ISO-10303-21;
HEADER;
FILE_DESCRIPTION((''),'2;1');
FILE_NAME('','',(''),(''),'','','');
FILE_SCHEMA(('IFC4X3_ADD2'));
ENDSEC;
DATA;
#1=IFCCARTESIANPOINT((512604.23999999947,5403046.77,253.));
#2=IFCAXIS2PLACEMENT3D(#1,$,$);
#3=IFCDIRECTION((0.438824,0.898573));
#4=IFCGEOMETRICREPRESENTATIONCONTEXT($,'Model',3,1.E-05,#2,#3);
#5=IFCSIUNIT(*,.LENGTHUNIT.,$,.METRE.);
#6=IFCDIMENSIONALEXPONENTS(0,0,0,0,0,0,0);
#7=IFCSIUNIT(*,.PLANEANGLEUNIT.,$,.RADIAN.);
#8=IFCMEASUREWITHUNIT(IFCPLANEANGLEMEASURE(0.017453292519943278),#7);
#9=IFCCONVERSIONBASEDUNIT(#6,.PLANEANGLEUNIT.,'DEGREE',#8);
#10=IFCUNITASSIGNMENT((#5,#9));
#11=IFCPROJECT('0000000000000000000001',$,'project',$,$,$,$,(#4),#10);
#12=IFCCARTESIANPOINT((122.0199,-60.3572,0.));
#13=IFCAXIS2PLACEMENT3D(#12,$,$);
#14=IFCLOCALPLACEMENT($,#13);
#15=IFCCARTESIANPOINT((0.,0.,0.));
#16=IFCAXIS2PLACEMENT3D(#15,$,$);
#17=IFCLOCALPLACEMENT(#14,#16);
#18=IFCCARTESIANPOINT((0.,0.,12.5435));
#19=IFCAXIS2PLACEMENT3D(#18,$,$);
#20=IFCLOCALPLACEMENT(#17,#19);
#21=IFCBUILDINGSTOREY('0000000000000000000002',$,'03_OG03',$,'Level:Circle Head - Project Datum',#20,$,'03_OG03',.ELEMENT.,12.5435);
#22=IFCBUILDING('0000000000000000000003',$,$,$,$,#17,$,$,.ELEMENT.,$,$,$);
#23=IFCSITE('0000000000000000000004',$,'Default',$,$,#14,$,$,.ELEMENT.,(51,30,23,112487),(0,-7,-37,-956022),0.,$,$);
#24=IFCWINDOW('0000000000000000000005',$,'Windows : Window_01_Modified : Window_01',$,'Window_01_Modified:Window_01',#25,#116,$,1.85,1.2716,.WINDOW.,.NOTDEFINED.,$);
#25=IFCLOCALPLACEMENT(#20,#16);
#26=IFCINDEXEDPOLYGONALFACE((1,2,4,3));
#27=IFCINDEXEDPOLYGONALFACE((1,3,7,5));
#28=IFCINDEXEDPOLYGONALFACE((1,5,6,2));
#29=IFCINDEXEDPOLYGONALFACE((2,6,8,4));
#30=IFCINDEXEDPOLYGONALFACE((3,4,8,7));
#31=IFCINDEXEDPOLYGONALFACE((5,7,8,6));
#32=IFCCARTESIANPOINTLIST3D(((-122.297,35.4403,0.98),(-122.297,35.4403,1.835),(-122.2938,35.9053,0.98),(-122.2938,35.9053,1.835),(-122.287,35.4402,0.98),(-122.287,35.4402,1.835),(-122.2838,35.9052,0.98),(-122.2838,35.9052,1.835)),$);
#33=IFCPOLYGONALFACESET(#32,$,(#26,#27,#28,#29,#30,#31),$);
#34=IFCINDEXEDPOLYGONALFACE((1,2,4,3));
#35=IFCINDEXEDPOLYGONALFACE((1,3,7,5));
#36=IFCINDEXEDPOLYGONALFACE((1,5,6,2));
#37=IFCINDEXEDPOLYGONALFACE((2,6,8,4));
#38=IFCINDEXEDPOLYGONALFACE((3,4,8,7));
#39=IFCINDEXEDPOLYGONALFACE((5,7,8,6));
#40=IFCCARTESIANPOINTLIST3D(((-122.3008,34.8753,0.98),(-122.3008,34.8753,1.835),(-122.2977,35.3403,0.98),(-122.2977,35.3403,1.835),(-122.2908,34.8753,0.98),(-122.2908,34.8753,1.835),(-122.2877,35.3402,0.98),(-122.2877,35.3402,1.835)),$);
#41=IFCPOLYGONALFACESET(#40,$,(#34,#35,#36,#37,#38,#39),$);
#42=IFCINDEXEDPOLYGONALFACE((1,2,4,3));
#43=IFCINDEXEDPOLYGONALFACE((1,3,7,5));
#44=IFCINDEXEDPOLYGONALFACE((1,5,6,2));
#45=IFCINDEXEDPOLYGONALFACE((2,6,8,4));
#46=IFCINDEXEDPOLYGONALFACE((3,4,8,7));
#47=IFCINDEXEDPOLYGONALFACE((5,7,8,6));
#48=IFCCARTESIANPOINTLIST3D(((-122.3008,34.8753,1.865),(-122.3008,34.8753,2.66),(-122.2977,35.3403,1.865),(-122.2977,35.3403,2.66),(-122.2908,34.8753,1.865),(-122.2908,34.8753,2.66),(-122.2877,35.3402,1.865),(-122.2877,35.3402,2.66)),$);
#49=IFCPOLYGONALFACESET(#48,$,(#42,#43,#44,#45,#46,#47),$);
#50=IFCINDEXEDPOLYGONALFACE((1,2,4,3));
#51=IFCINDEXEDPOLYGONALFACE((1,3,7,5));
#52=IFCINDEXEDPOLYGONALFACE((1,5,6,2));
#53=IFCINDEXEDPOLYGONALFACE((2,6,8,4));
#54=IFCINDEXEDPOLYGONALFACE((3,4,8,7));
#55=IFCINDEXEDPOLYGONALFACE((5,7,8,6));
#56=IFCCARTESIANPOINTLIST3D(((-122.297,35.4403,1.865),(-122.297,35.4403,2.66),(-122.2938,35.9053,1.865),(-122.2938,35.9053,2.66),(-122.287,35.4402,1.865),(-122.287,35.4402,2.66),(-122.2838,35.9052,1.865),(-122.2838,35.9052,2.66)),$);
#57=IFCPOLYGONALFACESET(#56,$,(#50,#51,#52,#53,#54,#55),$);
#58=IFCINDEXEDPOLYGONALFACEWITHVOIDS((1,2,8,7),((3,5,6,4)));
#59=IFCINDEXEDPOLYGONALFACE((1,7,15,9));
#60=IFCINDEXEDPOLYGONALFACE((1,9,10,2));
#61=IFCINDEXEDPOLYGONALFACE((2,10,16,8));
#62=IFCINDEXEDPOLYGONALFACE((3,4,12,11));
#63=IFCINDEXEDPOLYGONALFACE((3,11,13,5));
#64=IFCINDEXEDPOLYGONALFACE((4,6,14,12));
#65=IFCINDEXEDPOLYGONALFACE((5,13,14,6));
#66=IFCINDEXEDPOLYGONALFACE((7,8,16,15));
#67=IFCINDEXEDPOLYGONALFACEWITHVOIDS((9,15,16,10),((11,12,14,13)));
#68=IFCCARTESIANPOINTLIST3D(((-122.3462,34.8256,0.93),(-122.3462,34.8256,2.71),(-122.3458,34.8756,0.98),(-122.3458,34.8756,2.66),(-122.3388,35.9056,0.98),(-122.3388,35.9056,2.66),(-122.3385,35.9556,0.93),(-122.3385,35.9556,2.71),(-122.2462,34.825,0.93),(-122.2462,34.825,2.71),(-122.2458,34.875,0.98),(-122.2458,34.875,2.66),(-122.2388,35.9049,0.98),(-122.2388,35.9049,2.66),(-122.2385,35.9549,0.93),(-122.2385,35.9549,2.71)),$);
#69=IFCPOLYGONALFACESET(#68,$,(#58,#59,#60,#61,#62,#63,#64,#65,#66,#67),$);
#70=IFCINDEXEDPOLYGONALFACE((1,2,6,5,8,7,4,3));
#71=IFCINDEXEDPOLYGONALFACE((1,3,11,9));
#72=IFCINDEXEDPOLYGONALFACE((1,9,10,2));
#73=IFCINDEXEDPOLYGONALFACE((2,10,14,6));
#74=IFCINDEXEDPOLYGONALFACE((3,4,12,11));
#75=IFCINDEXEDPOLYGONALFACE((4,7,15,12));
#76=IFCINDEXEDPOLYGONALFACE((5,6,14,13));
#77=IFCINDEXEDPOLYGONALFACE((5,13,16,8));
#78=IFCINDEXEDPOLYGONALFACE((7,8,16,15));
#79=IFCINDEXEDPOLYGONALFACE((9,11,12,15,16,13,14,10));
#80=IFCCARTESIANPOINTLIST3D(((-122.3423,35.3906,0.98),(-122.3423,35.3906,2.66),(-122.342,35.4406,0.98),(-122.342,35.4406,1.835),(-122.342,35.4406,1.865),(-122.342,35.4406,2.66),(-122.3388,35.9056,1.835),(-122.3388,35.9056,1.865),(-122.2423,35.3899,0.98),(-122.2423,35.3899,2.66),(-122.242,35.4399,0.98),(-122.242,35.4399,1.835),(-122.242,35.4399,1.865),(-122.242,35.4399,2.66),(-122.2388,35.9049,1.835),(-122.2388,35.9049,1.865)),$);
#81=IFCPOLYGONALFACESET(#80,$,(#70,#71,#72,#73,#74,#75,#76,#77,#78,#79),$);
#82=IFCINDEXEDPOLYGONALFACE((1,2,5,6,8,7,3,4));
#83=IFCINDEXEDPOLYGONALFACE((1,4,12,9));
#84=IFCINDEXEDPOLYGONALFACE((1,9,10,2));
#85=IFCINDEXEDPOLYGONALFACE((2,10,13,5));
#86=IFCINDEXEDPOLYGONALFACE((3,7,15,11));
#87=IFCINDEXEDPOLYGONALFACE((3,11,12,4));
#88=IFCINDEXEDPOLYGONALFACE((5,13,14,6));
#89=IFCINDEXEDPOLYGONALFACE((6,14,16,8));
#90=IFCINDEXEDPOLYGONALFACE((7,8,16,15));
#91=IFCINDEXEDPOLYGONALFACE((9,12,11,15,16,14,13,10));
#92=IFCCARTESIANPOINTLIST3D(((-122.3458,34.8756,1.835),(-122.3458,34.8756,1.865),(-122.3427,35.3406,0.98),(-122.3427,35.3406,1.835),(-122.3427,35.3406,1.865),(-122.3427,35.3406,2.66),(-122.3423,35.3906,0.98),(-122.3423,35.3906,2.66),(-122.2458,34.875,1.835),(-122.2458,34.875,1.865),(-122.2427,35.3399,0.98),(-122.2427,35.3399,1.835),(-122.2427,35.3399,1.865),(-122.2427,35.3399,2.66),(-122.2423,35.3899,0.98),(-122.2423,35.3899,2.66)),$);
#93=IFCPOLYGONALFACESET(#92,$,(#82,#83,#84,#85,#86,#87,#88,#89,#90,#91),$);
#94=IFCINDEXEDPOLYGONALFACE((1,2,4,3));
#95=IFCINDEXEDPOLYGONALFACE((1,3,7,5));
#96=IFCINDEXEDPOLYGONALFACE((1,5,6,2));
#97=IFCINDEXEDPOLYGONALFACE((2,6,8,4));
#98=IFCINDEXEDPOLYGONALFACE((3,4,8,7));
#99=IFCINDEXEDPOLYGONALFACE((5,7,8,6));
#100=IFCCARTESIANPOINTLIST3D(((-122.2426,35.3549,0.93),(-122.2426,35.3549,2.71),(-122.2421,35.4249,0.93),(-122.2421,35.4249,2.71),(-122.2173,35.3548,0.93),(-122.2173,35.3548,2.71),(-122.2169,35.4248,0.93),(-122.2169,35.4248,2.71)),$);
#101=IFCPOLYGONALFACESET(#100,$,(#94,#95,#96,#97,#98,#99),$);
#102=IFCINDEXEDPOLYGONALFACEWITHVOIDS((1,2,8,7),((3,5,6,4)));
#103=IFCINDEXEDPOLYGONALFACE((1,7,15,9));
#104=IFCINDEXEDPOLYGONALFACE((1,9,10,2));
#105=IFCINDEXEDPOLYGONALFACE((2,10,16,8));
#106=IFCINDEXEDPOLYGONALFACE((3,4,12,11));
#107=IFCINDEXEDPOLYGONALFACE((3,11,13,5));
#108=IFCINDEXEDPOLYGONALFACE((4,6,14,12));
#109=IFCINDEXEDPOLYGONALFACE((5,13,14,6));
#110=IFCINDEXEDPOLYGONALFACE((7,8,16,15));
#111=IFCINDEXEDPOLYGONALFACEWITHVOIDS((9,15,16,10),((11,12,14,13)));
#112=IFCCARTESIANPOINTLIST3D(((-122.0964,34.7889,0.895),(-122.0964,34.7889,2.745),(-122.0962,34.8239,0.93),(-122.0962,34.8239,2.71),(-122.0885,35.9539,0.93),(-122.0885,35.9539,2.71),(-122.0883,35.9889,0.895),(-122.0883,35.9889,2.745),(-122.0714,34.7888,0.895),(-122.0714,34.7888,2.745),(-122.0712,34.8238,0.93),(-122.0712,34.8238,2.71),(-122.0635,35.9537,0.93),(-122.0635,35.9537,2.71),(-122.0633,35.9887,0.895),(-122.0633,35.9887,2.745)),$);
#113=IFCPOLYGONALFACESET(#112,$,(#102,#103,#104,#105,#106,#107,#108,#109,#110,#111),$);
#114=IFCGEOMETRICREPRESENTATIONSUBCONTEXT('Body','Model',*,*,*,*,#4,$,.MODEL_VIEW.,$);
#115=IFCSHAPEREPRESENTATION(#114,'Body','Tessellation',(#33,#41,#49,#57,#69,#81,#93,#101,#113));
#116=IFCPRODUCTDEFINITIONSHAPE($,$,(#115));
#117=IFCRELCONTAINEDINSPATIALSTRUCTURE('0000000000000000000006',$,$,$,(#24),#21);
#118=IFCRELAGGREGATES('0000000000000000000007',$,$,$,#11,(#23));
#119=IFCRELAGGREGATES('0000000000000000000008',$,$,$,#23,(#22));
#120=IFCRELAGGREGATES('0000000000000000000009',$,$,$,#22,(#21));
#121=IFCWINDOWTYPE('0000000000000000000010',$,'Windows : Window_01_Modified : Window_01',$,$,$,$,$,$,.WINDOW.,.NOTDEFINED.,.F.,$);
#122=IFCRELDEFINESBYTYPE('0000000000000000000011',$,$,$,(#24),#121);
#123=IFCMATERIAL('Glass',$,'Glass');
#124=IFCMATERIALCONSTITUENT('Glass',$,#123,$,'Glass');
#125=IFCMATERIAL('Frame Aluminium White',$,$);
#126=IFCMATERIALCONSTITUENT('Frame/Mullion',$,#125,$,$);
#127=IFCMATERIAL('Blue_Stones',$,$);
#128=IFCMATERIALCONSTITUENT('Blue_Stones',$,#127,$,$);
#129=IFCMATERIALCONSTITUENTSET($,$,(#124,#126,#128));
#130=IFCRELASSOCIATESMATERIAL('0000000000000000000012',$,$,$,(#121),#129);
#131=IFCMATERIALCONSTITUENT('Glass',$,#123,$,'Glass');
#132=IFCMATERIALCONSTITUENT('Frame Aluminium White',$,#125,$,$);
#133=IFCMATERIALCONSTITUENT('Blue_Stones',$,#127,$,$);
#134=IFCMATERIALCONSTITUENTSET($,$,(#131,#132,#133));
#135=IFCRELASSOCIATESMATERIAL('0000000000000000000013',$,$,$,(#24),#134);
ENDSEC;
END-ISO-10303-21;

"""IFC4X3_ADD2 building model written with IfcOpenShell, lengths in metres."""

from ifc_helpers import new_model, entity, si_unit, converted_unit, direction, frame, frame_2d, origin, place, context, subcontext, project, spatial, polyline, rectangle, outline, extrude, source, transform, mapped, material, constituent, constituent_set, type_object, type_shapes, element, save


model = new_model("IFC4X3_ADD2")

# Units and contexts
model_context = context("Model", 3, precision=1e-05, world=frame((512604.23999999947, 5403046.77, 253.0)), true_north=direction((0.438824, 0.898573)))
body_context = subcontext(model_context, "Body", "Model", "MODEL_VIEW")
ifc_project = project(units=[si_unit("LENGTHUNIT", "METRE"), converted_unit("PLANEANGLEUNIT", "DEGREE", entity("IfcPlaneAngleMeasure", 0.017453292519943278), si_unit("PLANEANGLEUNIT", "RADIAN"), dimensions=[0, 0, 0, 0, 0, 0, 0])], contexts=[model_context])

# Site, building, storey
site_placement = place(None, frame((122.0199, -60.3572, 0.0)))
site = spatial("IfcSite", under=ifc_project, at=site_placement, Name="Default", CompositionType="ELEMENT", RefLatitude=(51, 30, 23, 112487), RefLongitude=(0, -7, -37, -956022), RefElevation=0.0)
building_placement = place(site_placement, origin())
building = spatial("IfcBuilding", under=site, at=building_placement, CompositionType="ELEMENT")
storey_placement = place(building_placement, frame((0.0, 0.0, 12.5435)))
storey = spatial("IfcBuildingStorey", under=building, at=storey_placement, Name="03_OG03", ObjectType="Level:Circle Head - Project Datum", LongName="03_OG03", CompositionType="ELEMENT", Elevation=12.5435)

# Window
ifc_material_1 = material(Name="Glass", Category="Glass")
ifc_material_2 = material(Name="Frame Aluminium White")
ifc_material_3 = material(Name="Blue_Stones")
ifc_constituent_1 = constituent(ifc_material_1, Name="Glass", Category="Glass")
ifc_constituent_2 = constituent(ifc_material_2, Name="Frame Aluminium White")
ifc_constituent_3 = constituent(ifc_material_3, Name="Blue_Stones")
ifc_constituent_set_1 = constituent_set(constituents=[ifc_constituent_1, ifc_constituent_2, ifc_constituent_3])
ifc_constituent_4 = constituent(ifc_material_1, Name="Glass", Category="Glass")
ifc_constituent_5 = constituent(ifc_material_2, Name="Frame/Mullion")
ifc_constituent_6 = constituent(ifc_material_3, Name="Blue_Stones")
ifc_constituent_set_2 = constituent_set(constituents=[ifc_constituent_4, ifc_constituent_5, ifc_constituent_6])
window_type_1 = type_object("IfcWindowType", Name="Windows : Window_01_Modified : Window_01", ParameterTakesPrecedence=False, PartitioningType="NOTDEFINED", PredefinedType="WINDOW", material=ifc_constituent_set_2)
shared_shape_1 = source(origin(), body_context, "Body", "SweptSolid", [
    extrude(rectangle(XDim=0.465, YDim=0.01, at=frame_2d((0.0, 0.0), x_axis=(1.0, 0.0))), frame((0.3531, -0.2, 0.0514), z_axis=(0.0, 0.0, 1.0), x_axis=(-1.0, 0.0, 0.0)), (0.0, 0.0, 1.0), 0.855),
    extrude(rectangle(XDim=0.01, YDim=0.465, at=frame_2d((0.0, 0.0), x_axis=(1.0, 0.0))), frame((0.9181, -0.2, 0.0514), z_axis=(0.0, 0.0, 1.0), x_axis=(0.0, 1.0, 0.0)), (0.0, 0.0, 1.0), 0.855),
    extrude(rectangle(XDim=0.465, YDim=0.01, at=frame_2d((0.0, 0.0), x_axis=(1.0, 0.0))), frame((0.9181, -0.2, 0.9364), z_axis=(0.0, 0.0, 1.0), x_axis=(-1.0, 0.0, 0.0)), (0.0, 0.0, 1.0), 0.795),
    extrude(rectangle(XDim=0.465, YDim=0.01, at=frame_2d((0.0, 0.0), x_axis=(1.0, 0.0))), frame((0.3531, -0.2, 0.9364), z_axis=(0.0, 0.0, 1.0), x_axis=(-1.0, 0.0, 0.0)), (0.0, 0.0, 1.0), 0.795),
    extrude(outline(polyline([(-0.89, -0.565), (0.89, -0.565), (0.89, 0.565), (-0.89, 0.565), (-0.89, -0.565)]), holes=[polyline([(0.84, 0.515), (0.84, -0.515), (-0.84, -0.515), (-0.84, 0.515), (0.84, 0.515)])]), frame((0.6356, -0.25, 0.8914), z_axis=(0.0, 1.0, 0.0), x_axis=(0.0, 0.0, 1.0)), (0.0, 0.0, 1.0), 0.1),
    extrude(outline(polyline([(0.03, 0.1037), (0.825, 0.1037), (0.825, 0.1538), (-0.855, 0.1538), (-0.855, 0.1037), (0.0, 0.1037), (0.0, -0.3613), (0.03, -0.3613), (0.03, 0.1037)])), frame((0.4819, -0.25, 0.9064), z_axis=(0.0, 1.0, 0.0), x_axis=(0.0, 0.0, 1.0)), (0.0, 0.0, 1.0), 0.1),
    extrude(outline(polyline([(-0.825, -0.1038), (-0.825, -0.1538), (0.855, -0.1538), (0.855, -0.1038), (0.0, -0.1038), (0.0, 0.3613), (-0.03, 0.3613), (-0.03, -0.1038), (-0.825, -0.1038)])), frame((0.7894, -0.25, 0.9064), z_axis=(0.0, -1.0, 0.0), x_axis=(0.0, 0.0, -1.0)), (0.0, 0.0, -1.0), 0.1),
    extrude(rectangle(XDim=0.0253, YDim=0.07, at=frame_2d((0.0, 0.0), x_axis=(1.0, 0.0))), frame((0.6356, -0.1374, 0.0014), z_axis=(0.0, 0.0, 1.0), x_axis=(0.0, -1.0, 0.0)), (0.0, 0.0, 1.0), 1.78),
    extrude(outline(polyline([(-0.6, -0.925), (0.6, -0.925), (0.6, 0.925), (-0.6, 0.925), (-0.6, -0.925)]), holes=[polyline([(-0.565, -0.89), (-0.565, 0.89), (0.565, 0.89), (0.565, -0.89), (-0.565, -0.89)])]), frame((0.6356, 0.0, 0.8914), z_axis=(0.0, 1.0, 0.0), x_axis=(1.0, 0.0, 0.0)), (0.0, 0.0, 1.0), 0.025),
])
type_shapes(window_type_1, [shared_shape_1])
window_1_placement = place(storey_placement, frame((-122.088, 36.0245, 0.9286), z_axis=(0.0, 0.0, 1.0), x_axis=(-0.0068, -0.999977, 0.0)))
element("IfcWindow", 1, at=window_1_placement, inside=storey, type_object=window_type_1, material=ifc_constituent_set_1, Name="Windows : Window_01_Modified : Window_01", ObjectType="Window_01_Modified:Window_01", OverallHeight=1.85, OverallWidth=1.2716, PartitioningType="NOTDEFINED", PredefinedType="WINDOW", context=body_context, shape_type="MappedRepresentation", body=[
    mapped(shared_shape_1, transform((0.0, 0.0, 0.0), scale=1.0)),
])

save(model, "model.ifc")
